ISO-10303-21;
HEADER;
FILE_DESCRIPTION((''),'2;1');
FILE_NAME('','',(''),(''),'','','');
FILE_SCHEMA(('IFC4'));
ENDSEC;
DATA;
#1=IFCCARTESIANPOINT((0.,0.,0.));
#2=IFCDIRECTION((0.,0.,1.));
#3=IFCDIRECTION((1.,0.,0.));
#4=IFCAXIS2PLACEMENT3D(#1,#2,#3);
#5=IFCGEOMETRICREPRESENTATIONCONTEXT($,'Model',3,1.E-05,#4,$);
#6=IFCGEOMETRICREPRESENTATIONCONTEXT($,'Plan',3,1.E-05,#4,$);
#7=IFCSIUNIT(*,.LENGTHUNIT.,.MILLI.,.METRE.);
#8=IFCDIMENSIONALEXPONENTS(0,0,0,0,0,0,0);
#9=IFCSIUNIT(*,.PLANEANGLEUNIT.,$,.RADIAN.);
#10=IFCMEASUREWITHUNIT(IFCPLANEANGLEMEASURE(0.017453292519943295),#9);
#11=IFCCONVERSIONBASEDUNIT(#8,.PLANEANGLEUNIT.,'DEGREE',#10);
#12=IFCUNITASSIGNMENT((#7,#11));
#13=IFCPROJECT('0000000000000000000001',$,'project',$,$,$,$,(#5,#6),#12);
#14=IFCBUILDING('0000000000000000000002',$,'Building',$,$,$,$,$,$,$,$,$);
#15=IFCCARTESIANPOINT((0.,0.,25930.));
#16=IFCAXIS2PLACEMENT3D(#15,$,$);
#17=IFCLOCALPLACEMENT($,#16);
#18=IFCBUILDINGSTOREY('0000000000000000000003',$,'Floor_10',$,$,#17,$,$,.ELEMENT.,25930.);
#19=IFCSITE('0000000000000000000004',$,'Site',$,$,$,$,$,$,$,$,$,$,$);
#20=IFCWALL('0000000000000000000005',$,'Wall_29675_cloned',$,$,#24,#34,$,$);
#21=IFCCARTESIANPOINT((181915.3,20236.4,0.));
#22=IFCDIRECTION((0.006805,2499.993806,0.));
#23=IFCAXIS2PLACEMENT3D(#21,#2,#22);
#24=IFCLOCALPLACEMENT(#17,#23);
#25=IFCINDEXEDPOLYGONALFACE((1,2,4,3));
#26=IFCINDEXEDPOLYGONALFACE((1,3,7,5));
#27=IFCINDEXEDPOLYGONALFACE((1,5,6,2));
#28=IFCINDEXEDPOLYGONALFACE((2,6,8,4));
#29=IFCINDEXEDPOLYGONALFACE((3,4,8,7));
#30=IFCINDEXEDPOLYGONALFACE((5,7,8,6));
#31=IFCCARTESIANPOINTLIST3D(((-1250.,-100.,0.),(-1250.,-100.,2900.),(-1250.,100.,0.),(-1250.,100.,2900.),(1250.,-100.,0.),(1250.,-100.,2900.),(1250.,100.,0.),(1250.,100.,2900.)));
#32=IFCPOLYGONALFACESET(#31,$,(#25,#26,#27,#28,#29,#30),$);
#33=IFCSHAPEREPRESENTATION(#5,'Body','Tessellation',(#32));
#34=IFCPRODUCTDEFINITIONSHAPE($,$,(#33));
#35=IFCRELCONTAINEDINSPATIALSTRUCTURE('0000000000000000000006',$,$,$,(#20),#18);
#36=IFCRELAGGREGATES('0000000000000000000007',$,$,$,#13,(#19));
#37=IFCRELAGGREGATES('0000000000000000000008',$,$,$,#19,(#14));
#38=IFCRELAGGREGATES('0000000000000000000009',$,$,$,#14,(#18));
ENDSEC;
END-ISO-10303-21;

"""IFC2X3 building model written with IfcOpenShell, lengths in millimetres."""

from ifc_helpers import new_model, entity, si_unit, converted_unit, frame, origin_with_axes, origin_2d, place, context, project, spatial, rectangle, extrude, source, transform, mapped, element, save


model = new_model("IFC2X3")

# Units and contexts
model_context = context("Model", 3, precision=1e-05, world=origin_with_axes())
plan_context = context("Plan", 3, precision=1e-05, world=origin_with_axes())
ifc_project = project(units=[si_unit("LENGTHUNIT", "METRE", prefix="MILLI"), converted_unit("PLANEANGLEUNIT", "DEGREE", entity("IfcPlaneAngleMeasure", 0.017453292519943295), si_unit("PLANEANGLEUNIT", "RADIAN"), dimensions=[0, 0, 0, 0, 0, 0, 0])], contexts=[model_context, plan_context])

# Site, building, storey
site = spatial("IfcSite", under=ifc_project, Name="Site")
building = spatial("IfcBuilding", under=site, Name="Building")
storey_placement = place(None, frame((0.0, 0.0, 25930.0)))
storey = spatial("IfcBuildingStorey", under=building, at=storey_placement, Name="Floor_10", CompositionType="ELEMENT", Elevation=25930.0)

# Wall
shared_shape_1 = source(origin_with_axes(), model_context, "Body", "SweptSolid", [
    extrude(rectangle(XDim=2500.0, YDim=200.0, at=origin_2d()), origin_with_axes(), (0.0, 0.0, 1.0), 2900.0),
])
wall_1_placement = place(storey_placement, frame((181915.3, 20236.4, 0.0), z_axis=(0.0, 0.0, 1.0), x_axis=(0.006805, 2499.993806, 0.0)))
element("IfcWall", 1, at=wall_1_placement, inside=storey, Name="Wall_29675_cloned", context=model_context, shape_type="MappedRepresentation", body=[
    mapped(shared_shape_1, transform((0.0, 0.0, 0.0), x_axis=(1.0, 0.0, 0.0), y_axis=(0.0, 1.0, 0.0), z_axis=(0.0, 0.0, 1.0), scale=1.0)),
])

save(model, "model.ifc")
